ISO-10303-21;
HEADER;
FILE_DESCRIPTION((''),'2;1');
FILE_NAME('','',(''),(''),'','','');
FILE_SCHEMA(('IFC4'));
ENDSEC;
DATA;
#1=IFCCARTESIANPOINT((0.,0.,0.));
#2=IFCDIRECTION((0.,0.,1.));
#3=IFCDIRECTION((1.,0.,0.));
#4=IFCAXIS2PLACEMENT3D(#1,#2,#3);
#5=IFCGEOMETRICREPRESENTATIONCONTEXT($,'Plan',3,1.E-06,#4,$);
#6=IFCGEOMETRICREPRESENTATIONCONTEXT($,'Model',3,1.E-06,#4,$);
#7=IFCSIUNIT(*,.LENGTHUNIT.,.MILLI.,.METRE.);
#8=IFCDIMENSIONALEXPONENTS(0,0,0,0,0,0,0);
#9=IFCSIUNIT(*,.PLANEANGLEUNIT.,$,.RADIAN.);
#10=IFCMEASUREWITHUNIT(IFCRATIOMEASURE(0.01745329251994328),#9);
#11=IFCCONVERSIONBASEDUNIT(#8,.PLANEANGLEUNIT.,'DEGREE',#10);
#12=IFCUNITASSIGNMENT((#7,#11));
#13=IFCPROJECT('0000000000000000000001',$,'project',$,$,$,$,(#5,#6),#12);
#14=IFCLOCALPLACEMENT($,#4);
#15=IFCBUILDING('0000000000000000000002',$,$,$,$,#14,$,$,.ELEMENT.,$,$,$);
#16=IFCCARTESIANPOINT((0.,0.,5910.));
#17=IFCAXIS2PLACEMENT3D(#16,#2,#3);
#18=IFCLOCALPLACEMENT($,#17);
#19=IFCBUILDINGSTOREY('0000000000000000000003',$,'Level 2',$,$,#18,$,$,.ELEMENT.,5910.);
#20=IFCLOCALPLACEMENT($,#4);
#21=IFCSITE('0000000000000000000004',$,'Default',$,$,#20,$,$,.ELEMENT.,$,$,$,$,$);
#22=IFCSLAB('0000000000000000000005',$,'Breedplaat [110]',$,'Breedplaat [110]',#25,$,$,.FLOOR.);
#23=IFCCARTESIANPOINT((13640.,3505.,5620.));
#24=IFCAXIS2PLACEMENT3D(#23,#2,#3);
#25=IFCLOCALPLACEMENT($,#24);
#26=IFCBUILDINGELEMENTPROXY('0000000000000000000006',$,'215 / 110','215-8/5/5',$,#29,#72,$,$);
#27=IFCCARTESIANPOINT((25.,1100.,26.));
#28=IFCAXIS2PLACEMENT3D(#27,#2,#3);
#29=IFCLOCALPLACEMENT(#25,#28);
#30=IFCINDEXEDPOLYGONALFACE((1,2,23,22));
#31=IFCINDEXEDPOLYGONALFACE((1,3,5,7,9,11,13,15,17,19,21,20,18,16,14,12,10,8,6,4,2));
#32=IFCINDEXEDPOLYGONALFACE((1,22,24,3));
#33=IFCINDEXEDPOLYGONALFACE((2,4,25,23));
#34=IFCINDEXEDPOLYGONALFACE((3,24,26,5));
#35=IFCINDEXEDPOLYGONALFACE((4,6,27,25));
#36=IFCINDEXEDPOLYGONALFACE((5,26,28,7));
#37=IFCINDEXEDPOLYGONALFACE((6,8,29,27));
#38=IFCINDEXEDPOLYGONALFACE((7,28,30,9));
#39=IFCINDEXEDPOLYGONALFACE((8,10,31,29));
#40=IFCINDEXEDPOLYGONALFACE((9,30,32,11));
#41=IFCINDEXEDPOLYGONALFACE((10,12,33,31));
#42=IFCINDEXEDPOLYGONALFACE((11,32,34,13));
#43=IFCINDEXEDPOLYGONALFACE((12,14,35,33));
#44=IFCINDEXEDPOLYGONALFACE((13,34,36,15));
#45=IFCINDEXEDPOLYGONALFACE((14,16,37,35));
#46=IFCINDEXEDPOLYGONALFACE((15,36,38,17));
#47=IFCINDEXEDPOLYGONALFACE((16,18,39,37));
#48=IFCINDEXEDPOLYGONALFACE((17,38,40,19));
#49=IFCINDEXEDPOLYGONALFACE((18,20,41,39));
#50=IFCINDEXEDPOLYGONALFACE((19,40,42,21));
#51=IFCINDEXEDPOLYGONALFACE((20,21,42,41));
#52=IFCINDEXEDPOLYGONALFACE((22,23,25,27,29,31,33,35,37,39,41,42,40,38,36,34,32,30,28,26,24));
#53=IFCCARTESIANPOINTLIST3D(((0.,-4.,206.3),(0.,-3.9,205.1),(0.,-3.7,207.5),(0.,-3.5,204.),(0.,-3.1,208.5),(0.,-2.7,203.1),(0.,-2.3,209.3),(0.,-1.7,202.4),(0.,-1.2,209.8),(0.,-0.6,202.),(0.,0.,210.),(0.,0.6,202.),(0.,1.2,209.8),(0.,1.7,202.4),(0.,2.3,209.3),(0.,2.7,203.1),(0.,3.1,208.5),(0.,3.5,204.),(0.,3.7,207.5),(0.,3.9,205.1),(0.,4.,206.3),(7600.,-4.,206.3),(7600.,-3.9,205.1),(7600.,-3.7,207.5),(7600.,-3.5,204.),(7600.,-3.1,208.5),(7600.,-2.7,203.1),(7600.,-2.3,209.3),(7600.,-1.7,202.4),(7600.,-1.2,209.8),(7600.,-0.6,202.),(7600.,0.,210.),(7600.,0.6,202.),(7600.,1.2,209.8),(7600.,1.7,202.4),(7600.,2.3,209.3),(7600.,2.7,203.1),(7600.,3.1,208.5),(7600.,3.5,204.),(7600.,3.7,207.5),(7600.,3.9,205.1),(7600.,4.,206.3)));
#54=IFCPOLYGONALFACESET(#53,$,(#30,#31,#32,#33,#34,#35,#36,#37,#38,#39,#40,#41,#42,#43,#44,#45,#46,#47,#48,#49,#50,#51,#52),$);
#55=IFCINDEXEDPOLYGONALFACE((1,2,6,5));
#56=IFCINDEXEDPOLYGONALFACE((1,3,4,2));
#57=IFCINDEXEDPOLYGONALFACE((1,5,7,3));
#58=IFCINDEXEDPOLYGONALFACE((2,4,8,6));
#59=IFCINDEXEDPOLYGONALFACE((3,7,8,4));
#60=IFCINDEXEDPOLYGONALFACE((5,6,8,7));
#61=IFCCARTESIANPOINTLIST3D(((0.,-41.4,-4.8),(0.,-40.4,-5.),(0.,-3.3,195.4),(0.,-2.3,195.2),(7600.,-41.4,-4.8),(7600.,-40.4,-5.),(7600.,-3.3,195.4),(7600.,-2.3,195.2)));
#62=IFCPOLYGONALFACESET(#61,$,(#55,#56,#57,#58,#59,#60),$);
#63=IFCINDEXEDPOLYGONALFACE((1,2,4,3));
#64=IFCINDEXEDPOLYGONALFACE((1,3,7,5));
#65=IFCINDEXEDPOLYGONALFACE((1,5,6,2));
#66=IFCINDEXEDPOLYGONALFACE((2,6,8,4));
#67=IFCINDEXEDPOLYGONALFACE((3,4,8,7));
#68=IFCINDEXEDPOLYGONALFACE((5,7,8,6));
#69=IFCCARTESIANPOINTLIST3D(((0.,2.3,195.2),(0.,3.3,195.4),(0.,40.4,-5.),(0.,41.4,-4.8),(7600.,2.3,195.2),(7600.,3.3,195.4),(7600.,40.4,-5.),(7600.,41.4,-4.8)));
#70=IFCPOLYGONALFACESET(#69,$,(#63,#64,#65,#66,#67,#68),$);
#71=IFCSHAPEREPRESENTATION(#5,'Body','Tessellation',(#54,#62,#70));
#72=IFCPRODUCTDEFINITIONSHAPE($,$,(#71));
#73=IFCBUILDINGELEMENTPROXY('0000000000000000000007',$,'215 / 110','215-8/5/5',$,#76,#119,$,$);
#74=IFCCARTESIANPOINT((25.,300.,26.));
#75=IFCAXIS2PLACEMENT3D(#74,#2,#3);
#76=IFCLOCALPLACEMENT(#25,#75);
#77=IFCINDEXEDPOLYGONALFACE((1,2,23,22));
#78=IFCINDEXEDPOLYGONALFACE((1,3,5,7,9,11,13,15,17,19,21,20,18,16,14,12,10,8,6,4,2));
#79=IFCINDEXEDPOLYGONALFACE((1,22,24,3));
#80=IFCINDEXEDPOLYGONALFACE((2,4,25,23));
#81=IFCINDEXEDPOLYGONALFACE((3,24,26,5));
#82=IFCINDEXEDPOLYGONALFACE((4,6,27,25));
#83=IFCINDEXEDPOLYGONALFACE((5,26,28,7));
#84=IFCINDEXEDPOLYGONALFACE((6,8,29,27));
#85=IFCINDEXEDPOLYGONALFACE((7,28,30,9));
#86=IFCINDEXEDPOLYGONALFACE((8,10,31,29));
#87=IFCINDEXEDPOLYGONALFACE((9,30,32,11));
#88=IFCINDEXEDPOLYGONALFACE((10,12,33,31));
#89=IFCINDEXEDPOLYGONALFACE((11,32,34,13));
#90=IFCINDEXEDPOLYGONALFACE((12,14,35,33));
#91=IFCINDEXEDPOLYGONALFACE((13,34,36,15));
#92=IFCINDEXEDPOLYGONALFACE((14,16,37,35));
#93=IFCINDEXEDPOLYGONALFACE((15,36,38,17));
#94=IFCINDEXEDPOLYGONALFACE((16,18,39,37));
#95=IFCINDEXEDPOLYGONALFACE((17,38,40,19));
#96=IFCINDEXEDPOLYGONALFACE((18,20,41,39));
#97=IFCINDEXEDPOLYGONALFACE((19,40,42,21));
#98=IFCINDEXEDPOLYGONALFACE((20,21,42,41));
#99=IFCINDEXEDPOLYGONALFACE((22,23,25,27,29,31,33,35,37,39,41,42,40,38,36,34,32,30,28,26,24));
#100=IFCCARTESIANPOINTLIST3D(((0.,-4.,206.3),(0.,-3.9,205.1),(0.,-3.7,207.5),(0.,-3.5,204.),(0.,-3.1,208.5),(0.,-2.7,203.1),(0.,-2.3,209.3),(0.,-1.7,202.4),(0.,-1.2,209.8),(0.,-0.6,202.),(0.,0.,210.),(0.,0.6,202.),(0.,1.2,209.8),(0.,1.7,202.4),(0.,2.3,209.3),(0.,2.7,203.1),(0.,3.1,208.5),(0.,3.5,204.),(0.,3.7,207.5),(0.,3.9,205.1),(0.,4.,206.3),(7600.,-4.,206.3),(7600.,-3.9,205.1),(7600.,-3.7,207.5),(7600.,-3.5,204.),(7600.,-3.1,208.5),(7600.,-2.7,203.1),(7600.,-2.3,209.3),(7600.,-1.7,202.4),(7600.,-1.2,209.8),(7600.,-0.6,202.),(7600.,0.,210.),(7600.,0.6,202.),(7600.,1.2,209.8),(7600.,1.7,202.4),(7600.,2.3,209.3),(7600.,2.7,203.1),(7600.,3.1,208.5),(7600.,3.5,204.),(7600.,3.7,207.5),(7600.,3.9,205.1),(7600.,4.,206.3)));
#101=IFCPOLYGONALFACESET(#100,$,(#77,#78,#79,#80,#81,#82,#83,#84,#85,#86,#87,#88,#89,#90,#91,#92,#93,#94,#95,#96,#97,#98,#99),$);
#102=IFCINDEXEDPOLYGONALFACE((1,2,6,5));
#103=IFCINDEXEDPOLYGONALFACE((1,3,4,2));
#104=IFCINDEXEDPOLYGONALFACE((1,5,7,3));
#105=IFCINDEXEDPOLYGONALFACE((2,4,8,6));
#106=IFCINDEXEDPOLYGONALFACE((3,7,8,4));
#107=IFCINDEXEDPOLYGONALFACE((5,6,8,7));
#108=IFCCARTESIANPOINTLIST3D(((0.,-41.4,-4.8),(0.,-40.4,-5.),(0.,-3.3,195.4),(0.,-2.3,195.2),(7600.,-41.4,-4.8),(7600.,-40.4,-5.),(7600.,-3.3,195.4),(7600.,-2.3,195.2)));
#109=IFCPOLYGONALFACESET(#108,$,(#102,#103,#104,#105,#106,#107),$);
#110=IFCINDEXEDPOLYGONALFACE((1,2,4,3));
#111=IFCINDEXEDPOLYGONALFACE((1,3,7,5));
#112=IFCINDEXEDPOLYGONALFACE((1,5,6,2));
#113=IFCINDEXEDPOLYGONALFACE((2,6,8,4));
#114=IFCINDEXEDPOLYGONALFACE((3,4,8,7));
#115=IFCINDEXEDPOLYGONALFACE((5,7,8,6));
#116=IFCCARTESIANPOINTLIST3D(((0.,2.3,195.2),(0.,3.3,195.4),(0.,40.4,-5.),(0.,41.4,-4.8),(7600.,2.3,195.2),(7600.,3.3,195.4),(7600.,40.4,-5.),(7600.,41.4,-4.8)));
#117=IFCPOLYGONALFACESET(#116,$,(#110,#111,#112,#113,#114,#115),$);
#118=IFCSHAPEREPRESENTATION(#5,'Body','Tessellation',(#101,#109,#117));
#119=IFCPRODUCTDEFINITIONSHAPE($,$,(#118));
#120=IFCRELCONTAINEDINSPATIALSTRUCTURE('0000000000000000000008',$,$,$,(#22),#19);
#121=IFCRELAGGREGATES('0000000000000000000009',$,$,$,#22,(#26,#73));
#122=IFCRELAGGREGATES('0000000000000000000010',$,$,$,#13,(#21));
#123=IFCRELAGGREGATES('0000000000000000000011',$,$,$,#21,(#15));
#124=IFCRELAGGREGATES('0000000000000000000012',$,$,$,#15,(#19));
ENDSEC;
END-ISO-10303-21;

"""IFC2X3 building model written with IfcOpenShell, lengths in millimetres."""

from ifc_helpers import new_model, entity, si_unit, converted_unit, frame, origin_with_axes, origin_2d_with_axis, place, context, project, spatial, rectangle, circle, extrude, element, aggregate, save


model = new_model("IFC2X3")

# Units and contexts
plan_context = context("Plan", 3, precision=1e-06, world=origin_with_axes())
model_context = context("Model", 3, precision=1e-06, world=origin_with_axes())
ifc_project = project(units=[si_unit("LENGTHUNIT", "METRE", prefix="MILLI"), converted_unit("PLANEANGLEUNIT", "DEGREE", entity("IfcRatioMeasure", 0.01745329251994328), si_unit("PLANEANGLEUNIT", "RADIAN"), dimensions=[0, 0, 0, 0, 0, 0, 0])], contexts=[plan_context, model_context])

# Site, building, storey
site_placement = place(None, origin_with_axes())
site = spatial("IfcSite", under=ifc_project, at=site_placement, Name="Default", CompositionType="ELEMENT")
building_placement = place(None, origin_with_axes())
building = spatial("IfcBuilding", under=site, at=building_placement, CompositionType="ELEMENT")
storey_placement = place(None, frame((0.0, 0.0, 5910.0), z_axis=(0.0, 0.0, 1.0), x_axis=(1.0, 0.0, 0.0)))
storey = spatial("IfcBuildingStorey", under=building, at=storey_placement, Name="Level 2", CompositionType="ELEMENT", Elevation=5910.0)

# Slab, building element proxies
slab_1_placement = place(None, frame((13640.0, 3505.0, 5620.0), z_axis=(0.0, 0.0, 1.0), x_axis=(1.0, 0.0, 0.0)))
slab_1 = element("IfcSlab", 1, at=slab_1_placement, inside=storey, Name="Breedplaat [110]", ObjectType="Breedplaat [110]", PredefinedType="FLOOR")
proxy_1_placement = place(slab_1_placement, frame((25.0, 1100.0, 26.0), z_axis=(0.0, 0.0, 1.0), x_axis=(1.0, 0.0, 0.0)))
proxy_1 = element("IfcBuildingElementProxy", 2, at=proxy_1_placement, Name="215 / 110", Description="215-8/5/5", context=plan_context, shape_type="SweptSolid", body=[
    extrude(circle(Radius=4.0, at=origin_2d_with_axis()), frame((0.0, 0.0, 206.0), z_axis=(1.0, 0.0, 0.0), x_axis=(0.0, 0.0, 1.0)), (0.0, 0.0, 1.0), 7600.0),
    extrude(rectangle(XDim=203.8, YDim=1.0, at=origin_2d_with_axis()), frame((0.0, -21.9, 95.2), z_axis=(1.0, 0.0, 0.0), x_axis=(0.0, 0.187112, 0.982339)), (0.0, 0.0, 1.0), 7600.0),
    extrude(rectangle(XDim=203.8, YDim=1.0, at=origin_2d_with_axis()), frame((0.0, 21.9, 95.2), z_axis=(1.0, 0.0, 0.0), x_axis=(0.0, -0.187112, 0.982339)), (0.0, 0.0, 1.0), 7600.0),
])
proxy_2_placement = place(slab_1_placement, frame((25.0, 300.0, 26.0), z_axis=(0.0, 0.0, 1.0), x_axis=(1.0, 0.0, 0.0)))
proxy_2 = element("IfcBuildingElementProxy", 3, at=proxy_2_placement, Name="215 / 110", Description="215-8/5/5", context=plan_context, shape_type="SweptSolid", body=[
    extrude(circle(Radius=4.0, at=origin_2d_with_axis()), frame((0.0, 0.0, 206.0), z_axis=(1.0, 0.0, 0.0), x_axis=(0.0, 0.0, 1.0)), (0.0, 0.0, 1.0), 7600.0),
    extrude(rectangle(XDim=203.8, YDim=1.0, at=origin_2d_with_axis()), frame((0.0, -21.9, 95.2), z_axis=(1.0, 0.0, 0.0), x_axis=(0.0, 0.187112, 0.982339)), (0.0, 0.0, 1.0), 7600.0),
    extrude(rectangle(XDim=203.8, YDim=1.0, at=origin_2d_with_axis()), frame((0.0, 21.9, 95.2), z_axis=(1.0, 0.0, 0.0), x_axis=(0.0, -0.187112, 0.982339)), (0.0, 0.0, 1.0), 7600.0),
])
aggregate(slab_1, [proxy_1, proxy_2])

save(model, "model.ifc")
